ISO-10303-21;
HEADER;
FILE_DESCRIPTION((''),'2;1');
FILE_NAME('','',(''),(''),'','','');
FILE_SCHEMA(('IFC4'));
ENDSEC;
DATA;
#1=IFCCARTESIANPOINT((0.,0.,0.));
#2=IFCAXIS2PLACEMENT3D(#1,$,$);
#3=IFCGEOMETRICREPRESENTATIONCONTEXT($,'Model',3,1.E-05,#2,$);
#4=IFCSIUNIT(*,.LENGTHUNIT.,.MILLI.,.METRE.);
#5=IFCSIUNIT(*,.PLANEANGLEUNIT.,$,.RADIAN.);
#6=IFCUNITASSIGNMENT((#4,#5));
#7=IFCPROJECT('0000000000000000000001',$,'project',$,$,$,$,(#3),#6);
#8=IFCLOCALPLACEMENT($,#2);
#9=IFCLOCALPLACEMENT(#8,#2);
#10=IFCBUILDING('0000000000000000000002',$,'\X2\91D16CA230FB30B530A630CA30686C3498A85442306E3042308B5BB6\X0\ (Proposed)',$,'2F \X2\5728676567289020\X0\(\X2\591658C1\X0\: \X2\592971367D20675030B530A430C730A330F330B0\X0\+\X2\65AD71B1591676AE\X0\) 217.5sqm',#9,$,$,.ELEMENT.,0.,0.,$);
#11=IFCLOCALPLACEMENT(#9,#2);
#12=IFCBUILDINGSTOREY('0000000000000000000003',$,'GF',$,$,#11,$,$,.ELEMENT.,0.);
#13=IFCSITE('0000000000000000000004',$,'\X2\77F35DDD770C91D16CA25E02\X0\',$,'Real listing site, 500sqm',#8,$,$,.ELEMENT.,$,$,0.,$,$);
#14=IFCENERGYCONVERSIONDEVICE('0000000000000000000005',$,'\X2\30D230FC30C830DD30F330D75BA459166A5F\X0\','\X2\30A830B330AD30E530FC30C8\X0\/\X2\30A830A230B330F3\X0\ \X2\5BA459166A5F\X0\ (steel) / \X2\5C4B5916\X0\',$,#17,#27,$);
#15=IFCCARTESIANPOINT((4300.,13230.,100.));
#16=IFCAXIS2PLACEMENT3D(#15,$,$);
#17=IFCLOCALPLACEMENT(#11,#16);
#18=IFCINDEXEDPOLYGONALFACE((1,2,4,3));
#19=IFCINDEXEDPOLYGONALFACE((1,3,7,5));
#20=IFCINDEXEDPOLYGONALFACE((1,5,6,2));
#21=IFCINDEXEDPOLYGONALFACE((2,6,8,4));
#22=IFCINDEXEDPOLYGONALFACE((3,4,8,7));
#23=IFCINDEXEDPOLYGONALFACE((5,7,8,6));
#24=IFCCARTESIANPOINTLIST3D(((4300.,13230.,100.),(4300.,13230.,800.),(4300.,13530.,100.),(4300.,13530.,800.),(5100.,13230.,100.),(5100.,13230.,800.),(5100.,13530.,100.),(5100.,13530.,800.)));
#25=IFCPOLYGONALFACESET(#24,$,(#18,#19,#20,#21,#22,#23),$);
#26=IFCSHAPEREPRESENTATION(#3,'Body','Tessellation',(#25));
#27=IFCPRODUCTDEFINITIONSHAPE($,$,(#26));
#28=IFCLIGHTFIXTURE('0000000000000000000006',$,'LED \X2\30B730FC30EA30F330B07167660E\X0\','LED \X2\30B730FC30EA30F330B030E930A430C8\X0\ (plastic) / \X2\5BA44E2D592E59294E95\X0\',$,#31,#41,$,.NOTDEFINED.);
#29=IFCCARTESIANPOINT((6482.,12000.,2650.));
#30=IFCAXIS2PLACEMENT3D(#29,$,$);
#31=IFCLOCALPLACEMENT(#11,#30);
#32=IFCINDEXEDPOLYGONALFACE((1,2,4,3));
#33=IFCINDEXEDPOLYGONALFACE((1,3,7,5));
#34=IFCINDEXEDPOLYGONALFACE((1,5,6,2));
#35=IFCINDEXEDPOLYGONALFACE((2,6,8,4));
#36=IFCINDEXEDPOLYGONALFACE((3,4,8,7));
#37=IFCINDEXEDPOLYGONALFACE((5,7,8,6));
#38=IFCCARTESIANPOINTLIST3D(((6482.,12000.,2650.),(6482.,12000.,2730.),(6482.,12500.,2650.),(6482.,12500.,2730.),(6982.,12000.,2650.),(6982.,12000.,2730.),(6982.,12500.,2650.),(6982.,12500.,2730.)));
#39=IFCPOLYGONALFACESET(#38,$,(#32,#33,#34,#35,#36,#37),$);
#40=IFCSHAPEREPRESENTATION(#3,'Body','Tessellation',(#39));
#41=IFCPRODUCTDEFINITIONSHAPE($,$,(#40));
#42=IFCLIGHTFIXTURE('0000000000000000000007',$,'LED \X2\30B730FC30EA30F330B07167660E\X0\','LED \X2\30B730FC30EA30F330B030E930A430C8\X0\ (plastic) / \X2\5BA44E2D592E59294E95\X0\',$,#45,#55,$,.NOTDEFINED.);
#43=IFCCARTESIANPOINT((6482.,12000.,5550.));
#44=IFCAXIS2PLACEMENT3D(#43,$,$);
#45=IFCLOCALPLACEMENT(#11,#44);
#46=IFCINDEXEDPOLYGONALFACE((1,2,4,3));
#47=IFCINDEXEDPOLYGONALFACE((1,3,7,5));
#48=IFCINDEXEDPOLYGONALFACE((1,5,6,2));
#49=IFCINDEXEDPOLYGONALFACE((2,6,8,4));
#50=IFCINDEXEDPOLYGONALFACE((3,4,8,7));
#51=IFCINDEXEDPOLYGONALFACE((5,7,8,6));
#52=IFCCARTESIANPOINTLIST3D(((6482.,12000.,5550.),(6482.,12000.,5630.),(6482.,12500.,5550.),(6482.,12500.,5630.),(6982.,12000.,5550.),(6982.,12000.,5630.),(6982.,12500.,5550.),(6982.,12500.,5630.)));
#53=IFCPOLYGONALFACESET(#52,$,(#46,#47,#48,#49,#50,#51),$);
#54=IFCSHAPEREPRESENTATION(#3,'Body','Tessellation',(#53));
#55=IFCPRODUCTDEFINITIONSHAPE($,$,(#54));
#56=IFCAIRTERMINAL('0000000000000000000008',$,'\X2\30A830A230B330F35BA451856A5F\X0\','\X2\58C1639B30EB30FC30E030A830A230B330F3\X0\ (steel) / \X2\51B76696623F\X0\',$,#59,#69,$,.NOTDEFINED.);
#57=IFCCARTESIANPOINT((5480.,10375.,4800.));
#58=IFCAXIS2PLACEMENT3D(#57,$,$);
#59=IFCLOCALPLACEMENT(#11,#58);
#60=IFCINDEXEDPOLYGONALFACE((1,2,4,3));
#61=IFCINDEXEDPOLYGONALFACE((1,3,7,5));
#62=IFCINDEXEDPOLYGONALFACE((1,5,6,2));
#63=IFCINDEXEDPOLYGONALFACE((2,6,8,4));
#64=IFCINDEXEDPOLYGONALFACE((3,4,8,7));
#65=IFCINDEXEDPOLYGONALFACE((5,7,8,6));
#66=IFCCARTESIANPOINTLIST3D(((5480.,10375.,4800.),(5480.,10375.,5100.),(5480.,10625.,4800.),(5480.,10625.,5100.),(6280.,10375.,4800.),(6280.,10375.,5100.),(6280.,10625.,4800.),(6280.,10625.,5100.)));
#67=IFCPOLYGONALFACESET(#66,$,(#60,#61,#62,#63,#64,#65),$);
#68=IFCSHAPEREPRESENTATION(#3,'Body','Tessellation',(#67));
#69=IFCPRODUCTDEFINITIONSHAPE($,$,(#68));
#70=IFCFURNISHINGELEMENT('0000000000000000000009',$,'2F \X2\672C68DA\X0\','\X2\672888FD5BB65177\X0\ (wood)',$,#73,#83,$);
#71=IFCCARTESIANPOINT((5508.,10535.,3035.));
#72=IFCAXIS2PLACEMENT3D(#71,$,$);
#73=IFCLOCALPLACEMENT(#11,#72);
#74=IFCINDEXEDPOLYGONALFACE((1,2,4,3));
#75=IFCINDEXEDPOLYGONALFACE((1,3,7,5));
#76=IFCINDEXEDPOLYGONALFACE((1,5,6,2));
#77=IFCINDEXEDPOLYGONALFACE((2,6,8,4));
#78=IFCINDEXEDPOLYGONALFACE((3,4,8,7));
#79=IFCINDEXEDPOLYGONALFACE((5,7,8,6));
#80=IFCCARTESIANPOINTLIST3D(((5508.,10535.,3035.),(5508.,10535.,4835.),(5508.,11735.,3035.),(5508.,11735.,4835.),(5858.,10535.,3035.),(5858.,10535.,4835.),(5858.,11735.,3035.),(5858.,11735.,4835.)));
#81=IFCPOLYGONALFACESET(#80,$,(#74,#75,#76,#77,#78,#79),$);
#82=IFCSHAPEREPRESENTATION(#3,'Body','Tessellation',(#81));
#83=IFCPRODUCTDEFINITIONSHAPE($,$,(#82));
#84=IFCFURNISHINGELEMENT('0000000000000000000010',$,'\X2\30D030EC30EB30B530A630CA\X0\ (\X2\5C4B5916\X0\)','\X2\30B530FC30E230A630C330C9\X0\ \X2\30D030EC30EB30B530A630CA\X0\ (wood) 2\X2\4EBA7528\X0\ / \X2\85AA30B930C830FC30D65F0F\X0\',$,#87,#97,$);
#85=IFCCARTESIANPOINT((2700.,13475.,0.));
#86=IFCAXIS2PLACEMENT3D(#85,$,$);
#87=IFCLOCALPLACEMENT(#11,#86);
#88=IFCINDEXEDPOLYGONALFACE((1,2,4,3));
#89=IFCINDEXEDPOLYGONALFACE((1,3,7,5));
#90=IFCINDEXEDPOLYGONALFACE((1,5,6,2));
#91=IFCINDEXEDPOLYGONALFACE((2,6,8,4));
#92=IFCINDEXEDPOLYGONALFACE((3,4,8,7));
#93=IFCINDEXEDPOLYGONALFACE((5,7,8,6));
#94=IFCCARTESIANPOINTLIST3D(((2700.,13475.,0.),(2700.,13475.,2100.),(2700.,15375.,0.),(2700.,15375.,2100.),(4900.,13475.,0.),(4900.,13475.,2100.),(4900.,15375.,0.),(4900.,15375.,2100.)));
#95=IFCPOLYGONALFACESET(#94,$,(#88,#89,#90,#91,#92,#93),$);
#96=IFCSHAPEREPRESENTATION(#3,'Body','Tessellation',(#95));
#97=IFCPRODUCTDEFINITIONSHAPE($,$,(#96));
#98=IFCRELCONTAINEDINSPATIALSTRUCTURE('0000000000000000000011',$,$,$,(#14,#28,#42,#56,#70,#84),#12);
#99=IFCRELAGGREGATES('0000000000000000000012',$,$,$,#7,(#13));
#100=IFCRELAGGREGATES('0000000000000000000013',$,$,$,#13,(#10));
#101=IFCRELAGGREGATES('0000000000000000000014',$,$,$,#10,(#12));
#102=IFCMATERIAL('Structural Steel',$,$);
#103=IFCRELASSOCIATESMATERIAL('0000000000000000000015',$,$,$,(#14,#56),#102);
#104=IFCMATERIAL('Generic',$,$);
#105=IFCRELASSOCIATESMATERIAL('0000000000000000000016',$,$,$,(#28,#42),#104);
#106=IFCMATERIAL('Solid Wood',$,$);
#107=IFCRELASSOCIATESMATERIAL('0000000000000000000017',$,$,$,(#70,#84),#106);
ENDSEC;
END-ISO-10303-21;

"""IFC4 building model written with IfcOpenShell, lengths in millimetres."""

from ifc_helpers import new_model, si_unit, frame, frame_2d, origin, place, context, project, spatial, rectangle, extrude, material, element, save


model = new_model("IFC4")

# Units and contexts
model_context = context("Model", 3, precision=1e-05, world=origin())
ifc_project = project(units=[si_unit("LENGTHUNIT", "METRE", prefix="MILLI"), si_unit("PLANEANGLEUNIT", "RADIAN")], contexts=[model_context])

# Site, building, storey
site_placement = place(None, origin())
site = spatial("IfcSite", under=ifc_project, at=site_placement, Name="石川県金沢市", ObjectType="Real listing site, 500sqm", CompositionType="ELEMENT", RefElevation=0.0)
building_placement = place(site_placement, origin())
building = spatial("IfcBuilding", under=site, at=building_placement, Name="金沢・サウナと水風呂のある家 (Proposed)", ObjectType="2F 在来木造(外壁: 天然素材サイディング+断熱外皮) 217.5sqm", CompositionType="ELEMENT", ElevationOfRefHeight=0.0, ElevationOfTerrain=0.0)
storey_placement = place(building_placement, origin())
storey = spatial("IfcBuildingStorey", under=building, at=storey_placement, Name="GF", CompositionType="ELEMENT", Elevation=0.0)

# Shared definitions
ifc_material_1 = material(Name="Solid Wood")

# Shared definitions
ifc_material_2 = material(Name="Structural Steel")

# Shared definitions
ifc_material_3 = material(Name="Generic")

# Energy conversion device
energy_conversion_device_placement = place(storey_placement, frame((4300.0, 13230.0, 100.0)))
element("IfcEnergyConversionDevice", 1, at=energy_conversion_device_placement, inside=storey, material=ifc_material_2, Name="ヒートポンプ室外機", Description="エコキュート/エアコン 室外機 (steel) / 屋外", context=model_context, shape_type="SweptSolid", body=[
    extrude(rectangle(XDim=800.0, YDim=300.0, at=frame_2d((400.0, 150.0))), frame((4300.0, 13230.0, 100.0)), (0.0, 0.0, 1.0), 700.0),
])

# Light fixtures
light_fixture_1_placement = place(storey_placement, frame((6482.0, 12000.0, 2650.0)))
element("IfcLightFixture", 2, at=light_fixture_1_placement, inside=storey, material=ifc_material_3, Name="LED シーリング照明", Description="LED シーリングライト (plastic) / 室中央天井", PredefinedType="NOTDEFINED", context=model_context, shape_type="SweptSolid", body=[
    extrude(rectangle(XDim=500.0, YDim=500.0, at=frame_2d((250.0, 250.0))), frame((6482.0, 12000.0, 2650.0)), (0.0, 0.0, 1.0), 80.0),
])
light_fixture_2_placement = place(storey_placement, frame((6482.0, 12000.0, 5550.0)))
element("IfcLightFixture", 3, at=light_fixture_2_placement, inside=storey, material=ifc_material_3, Name="LED シーリング照明", Description="LED シーリングライト (plastic) / 室中央天井", PredefinedType="NOTDEFINED", context=model_context, shape_type="SweptSolid", body=[
    extrude(rectangle(XDim=500.0, YDim=500.0, at=frame_2d((250.0, 250.0))), frame((6482.0, 12000.0, 5550.0)), (0.0, 0.0, 1.0), 80.0),
])

# Air terminal
air_terminal_placement = place(storey_placement, frame((5480.0, 10375.0, 4800.0)))
element("IfcAirTerminal", 4, at=air_terminal_placement, inside=storey, material=ifc_material_2, Name="エアコン室内機", Description="壁掛ルームエアコン (steel) / 冷暖房", PredefinedType="NOTDEFINED", context=model_context, shape_type="SweptSolid", body=[
    extrude(rectangle(XDim=800.0, YDim=250.0, at=frame_2d((400.0, 125.0))), frame((5480.0, 10375.0, 4800.0)), (0.0, 0.0, 1.0), 300.0),
])

# Furnishing elements
furnishing_1_placement = place(storey_placement, frame((5508.0, 10535.0, 3035.0)))
element("IfcFurnishingElement", 5, at=furnishing_1_placement, inside=storey, material=ifc_material_1, Name="2F 本棚", Description="木製家具 (wood)", context=model_context, shape_type="SweptSolid", body=[
    extrude(rectangle(XDim=350.0, YDim=1200.0, at=frame_2d((175.0, 600.0))), frame((5508.0, 10535.0, 3035.0)), (0.0, 0.0, 1.0), 1800.0),
])
furnishing_2_placement = place(storey_placement, frame((2700.0, 13475.0, 0.0)))
element("IfcFurnishingElement", 6, at=furnishing_2_placement, inside=storey, material=ifc_material_1, Name="バレルサウナ (屋外)", Description="サーモウッド バレルサウナ (wood) 2人用 / 薪ストーブ式", context=model_context, shape_type="SweptSolid", body=[
    extrude(rectangle(XDim=2200.0, YDim=1900.0, at=frame_2d((1100.0, 950.0))), frame((2700.0, 13475.0, 0.0)), (0.0, 0.0, 1.0), 2100.0),
])

save(model, "model.ifc")
